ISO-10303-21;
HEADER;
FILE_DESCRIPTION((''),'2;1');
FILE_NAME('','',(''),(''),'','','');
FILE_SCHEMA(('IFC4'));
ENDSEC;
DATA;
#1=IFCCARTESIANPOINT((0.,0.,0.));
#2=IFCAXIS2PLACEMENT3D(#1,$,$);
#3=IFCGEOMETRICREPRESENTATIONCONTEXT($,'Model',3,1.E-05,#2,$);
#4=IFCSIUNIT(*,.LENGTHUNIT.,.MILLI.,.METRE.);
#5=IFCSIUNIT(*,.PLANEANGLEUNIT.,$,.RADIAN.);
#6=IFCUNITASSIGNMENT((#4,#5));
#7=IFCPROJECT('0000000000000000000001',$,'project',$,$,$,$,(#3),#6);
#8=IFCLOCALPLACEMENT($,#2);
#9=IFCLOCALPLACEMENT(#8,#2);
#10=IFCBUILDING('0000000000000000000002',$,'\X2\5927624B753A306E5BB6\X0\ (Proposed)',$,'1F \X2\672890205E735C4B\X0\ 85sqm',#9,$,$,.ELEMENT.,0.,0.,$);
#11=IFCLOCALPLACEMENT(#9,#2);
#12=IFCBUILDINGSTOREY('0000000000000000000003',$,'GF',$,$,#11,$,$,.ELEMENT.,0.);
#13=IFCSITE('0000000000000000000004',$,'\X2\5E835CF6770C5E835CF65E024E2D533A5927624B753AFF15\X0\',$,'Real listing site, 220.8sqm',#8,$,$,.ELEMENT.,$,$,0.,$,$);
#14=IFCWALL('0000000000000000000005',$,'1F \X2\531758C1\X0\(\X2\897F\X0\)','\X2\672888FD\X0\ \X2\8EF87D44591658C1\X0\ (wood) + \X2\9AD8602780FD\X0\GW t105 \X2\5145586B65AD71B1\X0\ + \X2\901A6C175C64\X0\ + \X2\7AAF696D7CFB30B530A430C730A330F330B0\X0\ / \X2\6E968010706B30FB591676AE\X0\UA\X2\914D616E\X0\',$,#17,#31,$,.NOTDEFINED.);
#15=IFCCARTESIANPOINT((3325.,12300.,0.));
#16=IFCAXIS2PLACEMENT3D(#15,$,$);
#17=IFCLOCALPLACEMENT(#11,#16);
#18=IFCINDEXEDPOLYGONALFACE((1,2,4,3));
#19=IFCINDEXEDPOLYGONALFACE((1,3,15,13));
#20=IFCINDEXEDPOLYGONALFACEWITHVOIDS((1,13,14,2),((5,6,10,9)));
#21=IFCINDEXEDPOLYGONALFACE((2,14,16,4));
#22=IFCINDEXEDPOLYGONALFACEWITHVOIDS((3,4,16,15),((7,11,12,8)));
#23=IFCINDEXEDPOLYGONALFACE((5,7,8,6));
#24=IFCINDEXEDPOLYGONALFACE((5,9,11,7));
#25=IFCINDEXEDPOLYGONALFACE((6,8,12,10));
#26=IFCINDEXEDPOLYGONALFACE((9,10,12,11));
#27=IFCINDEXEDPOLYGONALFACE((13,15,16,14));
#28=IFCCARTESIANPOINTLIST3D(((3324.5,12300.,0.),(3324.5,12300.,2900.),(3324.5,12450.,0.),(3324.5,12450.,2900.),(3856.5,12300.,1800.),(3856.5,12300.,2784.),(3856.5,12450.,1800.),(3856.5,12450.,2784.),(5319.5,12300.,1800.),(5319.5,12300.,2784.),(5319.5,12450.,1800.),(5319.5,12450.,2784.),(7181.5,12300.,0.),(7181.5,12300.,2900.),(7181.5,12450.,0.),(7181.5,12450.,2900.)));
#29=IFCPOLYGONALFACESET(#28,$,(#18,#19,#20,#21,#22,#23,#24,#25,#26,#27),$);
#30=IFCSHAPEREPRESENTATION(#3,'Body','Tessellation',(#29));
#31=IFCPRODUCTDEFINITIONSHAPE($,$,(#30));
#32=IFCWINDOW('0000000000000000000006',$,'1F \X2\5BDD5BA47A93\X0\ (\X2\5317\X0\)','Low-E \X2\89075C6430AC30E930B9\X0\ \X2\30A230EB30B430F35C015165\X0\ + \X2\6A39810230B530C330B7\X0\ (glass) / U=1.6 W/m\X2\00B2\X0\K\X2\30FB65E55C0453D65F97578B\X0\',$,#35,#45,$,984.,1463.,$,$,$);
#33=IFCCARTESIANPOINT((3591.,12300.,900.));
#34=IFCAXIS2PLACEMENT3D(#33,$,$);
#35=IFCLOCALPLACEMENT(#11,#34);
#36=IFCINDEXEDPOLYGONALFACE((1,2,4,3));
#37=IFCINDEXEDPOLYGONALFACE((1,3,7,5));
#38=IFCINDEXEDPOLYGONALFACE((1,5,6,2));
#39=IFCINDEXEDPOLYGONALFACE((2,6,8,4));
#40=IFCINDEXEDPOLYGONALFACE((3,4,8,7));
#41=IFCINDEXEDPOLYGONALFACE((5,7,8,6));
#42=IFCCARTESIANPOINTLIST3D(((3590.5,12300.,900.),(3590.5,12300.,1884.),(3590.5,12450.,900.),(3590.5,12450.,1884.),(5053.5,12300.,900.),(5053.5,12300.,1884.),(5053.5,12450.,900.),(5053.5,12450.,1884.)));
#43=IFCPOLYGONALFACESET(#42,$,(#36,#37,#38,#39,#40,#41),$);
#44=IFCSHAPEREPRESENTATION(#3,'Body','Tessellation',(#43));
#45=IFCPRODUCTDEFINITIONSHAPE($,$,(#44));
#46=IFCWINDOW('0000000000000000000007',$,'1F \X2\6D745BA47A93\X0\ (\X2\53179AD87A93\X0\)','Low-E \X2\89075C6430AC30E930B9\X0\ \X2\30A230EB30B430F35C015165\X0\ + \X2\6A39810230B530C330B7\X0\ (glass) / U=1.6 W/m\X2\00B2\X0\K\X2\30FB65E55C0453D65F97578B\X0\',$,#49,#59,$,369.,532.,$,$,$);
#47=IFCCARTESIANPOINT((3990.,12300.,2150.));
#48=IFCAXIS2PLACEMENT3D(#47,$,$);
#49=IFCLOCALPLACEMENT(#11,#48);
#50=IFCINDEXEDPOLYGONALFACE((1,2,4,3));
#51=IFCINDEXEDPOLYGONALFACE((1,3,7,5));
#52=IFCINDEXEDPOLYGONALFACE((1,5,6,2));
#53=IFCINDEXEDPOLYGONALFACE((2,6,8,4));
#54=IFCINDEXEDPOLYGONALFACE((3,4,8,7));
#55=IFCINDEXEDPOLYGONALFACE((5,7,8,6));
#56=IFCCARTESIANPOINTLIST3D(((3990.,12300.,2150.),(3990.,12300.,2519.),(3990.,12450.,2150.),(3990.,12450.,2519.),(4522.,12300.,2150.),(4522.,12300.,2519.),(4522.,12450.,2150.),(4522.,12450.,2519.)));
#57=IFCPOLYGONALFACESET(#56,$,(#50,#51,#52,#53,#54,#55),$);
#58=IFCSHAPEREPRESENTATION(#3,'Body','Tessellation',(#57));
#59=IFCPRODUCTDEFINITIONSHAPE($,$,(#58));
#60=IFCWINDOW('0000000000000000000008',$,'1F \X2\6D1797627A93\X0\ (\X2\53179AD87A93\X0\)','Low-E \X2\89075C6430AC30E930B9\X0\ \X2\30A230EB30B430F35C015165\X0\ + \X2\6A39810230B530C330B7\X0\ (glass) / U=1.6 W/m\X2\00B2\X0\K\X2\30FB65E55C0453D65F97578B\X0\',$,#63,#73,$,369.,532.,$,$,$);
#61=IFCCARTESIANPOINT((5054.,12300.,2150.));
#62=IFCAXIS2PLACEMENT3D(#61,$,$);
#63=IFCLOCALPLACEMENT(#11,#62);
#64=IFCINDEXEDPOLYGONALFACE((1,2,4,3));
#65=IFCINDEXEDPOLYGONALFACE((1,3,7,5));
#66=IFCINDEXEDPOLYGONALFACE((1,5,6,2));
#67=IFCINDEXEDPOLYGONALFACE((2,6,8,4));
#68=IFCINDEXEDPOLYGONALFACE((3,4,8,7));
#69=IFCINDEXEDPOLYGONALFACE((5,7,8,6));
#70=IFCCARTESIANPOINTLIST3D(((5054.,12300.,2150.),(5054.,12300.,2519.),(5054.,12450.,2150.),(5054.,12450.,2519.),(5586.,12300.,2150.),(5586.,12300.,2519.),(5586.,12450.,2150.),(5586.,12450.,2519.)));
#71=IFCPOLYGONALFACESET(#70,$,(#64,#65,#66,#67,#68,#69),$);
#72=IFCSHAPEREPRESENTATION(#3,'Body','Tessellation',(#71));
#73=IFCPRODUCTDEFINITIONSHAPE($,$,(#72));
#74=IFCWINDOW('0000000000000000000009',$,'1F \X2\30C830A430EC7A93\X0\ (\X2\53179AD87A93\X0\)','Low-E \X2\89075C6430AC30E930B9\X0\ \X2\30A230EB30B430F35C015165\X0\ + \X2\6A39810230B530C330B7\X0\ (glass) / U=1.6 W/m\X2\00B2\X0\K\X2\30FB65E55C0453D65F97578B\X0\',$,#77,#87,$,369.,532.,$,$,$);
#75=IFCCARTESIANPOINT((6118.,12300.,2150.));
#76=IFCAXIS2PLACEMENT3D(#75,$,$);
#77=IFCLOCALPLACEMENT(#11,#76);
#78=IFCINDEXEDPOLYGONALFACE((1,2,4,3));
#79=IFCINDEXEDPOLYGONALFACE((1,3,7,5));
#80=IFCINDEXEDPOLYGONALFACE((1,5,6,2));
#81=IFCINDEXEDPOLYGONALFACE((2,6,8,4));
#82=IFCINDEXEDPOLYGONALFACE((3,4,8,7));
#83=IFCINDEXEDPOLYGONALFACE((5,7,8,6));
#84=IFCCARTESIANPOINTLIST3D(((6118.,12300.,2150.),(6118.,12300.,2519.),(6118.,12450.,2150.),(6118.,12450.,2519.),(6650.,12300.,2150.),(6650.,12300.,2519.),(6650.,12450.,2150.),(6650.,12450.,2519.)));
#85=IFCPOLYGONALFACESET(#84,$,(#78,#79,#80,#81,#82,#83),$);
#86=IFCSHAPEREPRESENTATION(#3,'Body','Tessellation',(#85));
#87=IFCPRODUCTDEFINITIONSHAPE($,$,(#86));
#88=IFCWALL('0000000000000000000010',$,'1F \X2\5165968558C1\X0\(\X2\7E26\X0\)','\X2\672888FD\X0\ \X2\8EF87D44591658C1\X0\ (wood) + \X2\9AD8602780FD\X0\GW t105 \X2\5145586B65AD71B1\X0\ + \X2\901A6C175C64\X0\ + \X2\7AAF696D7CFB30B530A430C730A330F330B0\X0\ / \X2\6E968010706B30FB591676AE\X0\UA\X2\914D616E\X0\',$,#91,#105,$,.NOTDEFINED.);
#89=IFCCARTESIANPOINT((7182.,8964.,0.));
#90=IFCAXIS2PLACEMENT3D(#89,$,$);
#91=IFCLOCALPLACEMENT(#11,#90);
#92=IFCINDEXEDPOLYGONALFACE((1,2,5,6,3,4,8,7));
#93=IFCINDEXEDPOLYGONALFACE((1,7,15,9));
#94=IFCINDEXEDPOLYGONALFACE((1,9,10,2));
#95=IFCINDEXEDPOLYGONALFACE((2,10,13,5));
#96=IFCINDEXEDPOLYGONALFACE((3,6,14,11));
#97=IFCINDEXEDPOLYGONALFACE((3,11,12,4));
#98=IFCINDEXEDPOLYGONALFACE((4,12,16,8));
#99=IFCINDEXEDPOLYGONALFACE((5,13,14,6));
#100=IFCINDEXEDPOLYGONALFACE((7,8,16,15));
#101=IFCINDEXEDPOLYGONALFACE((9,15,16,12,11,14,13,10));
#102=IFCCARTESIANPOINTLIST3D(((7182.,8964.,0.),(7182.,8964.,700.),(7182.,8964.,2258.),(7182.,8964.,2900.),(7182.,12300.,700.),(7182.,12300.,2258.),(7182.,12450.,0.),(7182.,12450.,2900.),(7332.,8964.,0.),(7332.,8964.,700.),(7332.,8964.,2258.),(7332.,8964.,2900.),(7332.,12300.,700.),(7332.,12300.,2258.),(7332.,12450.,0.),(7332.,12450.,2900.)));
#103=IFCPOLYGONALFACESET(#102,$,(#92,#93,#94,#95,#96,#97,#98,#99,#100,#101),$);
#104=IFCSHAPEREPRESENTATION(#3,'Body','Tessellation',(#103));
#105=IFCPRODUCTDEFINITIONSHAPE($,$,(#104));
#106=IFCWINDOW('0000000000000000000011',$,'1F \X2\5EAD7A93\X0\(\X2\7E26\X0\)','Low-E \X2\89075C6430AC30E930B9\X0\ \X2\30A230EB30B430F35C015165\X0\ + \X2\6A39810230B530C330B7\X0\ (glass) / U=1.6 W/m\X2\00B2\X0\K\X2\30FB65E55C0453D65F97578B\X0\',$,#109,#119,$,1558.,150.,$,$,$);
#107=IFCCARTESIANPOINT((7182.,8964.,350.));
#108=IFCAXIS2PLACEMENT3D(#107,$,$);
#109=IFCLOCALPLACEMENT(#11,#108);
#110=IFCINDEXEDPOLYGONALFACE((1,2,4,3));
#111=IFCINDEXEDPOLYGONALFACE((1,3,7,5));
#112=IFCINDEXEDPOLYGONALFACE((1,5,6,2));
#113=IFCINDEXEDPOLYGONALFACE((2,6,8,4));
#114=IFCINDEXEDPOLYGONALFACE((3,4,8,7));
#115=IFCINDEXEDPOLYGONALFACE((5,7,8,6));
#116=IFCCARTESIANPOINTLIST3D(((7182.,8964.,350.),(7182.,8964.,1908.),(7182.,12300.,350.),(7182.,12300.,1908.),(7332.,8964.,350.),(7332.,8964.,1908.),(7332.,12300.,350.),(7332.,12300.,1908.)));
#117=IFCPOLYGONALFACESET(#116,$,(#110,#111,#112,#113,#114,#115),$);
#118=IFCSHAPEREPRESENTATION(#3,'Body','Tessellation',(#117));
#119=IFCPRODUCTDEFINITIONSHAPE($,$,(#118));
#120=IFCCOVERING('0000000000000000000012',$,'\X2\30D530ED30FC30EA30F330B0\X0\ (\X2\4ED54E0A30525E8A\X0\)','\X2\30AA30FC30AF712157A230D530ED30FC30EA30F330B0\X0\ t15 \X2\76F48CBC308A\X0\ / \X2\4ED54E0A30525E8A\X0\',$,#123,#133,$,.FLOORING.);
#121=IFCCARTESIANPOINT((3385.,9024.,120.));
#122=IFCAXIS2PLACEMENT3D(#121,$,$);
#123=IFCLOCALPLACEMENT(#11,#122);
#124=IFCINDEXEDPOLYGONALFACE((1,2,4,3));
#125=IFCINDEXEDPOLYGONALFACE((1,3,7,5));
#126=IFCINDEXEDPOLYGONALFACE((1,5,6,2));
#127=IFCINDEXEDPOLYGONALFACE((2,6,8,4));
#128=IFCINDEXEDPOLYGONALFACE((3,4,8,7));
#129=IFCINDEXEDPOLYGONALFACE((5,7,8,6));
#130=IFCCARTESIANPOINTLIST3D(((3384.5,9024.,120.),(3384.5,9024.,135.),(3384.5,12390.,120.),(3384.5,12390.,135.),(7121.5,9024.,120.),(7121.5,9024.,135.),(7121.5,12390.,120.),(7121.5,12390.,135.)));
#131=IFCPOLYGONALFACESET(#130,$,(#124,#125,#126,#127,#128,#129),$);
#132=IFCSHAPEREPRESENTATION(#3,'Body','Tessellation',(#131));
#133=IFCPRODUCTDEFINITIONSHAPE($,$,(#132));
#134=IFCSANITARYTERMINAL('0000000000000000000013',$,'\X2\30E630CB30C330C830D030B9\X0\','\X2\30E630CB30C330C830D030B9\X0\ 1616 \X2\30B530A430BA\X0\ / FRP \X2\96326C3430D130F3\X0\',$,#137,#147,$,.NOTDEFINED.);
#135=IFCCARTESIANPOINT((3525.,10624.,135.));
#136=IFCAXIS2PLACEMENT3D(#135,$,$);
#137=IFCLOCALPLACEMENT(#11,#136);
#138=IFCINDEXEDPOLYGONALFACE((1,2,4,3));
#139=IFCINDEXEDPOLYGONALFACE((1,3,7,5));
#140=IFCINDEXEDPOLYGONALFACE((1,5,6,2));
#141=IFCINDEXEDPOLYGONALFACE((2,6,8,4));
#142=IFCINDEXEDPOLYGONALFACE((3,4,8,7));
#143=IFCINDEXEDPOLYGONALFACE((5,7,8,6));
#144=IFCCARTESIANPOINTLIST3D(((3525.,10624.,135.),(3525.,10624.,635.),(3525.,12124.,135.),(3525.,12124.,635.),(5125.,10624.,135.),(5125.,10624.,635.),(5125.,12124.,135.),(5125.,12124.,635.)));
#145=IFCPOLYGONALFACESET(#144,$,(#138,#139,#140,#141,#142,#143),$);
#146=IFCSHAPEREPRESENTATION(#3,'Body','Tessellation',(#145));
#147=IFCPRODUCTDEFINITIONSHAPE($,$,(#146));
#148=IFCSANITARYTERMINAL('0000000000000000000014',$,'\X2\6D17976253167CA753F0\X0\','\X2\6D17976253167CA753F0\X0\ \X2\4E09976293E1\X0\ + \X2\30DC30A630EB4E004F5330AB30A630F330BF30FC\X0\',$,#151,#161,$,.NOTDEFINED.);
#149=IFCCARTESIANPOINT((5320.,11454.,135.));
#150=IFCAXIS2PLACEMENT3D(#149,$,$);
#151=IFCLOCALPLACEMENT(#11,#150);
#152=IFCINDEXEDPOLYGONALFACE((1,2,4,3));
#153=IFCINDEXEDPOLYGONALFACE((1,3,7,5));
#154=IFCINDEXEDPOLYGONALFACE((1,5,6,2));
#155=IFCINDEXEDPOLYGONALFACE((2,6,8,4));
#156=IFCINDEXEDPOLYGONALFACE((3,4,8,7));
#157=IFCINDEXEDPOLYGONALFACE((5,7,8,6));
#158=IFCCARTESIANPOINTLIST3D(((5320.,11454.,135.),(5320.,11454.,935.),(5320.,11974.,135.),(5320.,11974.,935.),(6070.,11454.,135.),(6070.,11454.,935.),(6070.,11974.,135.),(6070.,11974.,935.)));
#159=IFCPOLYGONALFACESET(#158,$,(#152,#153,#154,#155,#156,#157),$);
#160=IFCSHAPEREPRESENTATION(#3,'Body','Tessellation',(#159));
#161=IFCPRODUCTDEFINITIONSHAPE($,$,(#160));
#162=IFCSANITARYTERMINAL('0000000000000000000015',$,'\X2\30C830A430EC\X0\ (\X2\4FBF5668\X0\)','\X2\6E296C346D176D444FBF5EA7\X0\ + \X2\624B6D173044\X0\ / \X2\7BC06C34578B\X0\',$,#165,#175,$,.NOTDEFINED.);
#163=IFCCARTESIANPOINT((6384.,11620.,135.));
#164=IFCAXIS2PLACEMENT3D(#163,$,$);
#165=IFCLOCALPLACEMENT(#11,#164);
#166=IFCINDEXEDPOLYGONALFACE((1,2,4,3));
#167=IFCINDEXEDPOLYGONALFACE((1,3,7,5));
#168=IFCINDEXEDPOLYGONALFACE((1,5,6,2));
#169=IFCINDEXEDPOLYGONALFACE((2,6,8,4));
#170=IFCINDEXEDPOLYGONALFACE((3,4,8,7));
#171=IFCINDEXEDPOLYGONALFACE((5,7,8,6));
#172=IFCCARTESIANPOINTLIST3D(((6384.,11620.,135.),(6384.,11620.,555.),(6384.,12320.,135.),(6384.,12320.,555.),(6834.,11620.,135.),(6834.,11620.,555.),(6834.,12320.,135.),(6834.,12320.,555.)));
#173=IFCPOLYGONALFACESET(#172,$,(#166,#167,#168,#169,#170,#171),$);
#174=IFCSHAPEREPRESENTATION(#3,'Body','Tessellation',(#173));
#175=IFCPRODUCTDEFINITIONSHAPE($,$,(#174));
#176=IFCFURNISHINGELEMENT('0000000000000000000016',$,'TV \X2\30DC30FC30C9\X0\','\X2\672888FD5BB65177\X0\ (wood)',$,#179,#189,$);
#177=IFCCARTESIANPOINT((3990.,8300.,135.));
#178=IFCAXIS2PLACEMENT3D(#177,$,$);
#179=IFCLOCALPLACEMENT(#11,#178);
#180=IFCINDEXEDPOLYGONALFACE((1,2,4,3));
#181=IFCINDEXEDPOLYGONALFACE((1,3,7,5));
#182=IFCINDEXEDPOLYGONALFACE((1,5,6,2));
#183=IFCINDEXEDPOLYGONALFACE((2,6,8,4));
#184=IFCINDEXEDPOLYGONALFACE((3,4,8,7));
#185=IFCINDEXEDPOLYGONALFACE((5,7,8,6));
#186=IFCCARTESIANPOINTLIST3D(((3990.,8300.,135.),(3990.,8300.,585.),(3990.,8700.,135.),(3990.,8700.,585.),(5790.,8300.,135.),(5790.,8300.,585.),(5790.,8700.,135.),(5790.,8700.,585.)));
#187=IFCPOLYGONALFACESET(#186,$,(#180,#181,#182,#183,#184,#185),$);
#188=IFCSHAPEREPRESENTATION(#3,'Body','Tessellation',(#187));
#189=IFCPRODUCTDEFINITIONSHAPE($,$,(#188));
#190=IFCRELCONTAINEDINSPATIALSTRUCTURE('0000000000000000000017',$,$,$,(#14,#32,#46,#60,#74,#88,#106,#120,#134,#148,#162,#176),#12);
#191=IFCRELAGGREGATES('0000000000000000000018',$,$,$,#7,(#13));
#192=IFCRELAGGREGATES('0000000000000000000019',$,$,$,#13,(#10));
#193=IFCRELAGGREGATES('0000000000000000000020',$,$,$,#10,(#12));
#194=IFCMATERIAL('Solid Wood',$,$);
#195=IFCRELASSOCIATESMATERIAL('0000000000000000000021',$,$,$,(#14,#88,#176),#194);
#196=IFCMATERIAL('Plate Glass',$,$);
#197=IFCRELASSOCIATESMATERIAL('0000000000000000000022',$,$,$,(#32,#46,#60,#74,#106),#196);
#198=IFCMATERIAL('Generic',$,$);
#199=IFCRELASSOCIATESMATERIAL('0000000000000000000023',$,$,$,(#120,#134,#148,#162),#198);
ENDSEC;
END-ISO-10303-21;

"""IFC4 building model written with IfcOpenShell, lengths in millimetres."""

from ifc_helpers import new_model, si_unit, frame, frame_2d, origin, place, context, project, spatial, rectangle, extrude, material, element, fill, save


model = new_model("IFC4")

# Units and contexts
model_context = context("Model", 3, precision=1e-05, world=origin())
ifc_project = project(units=[si_unit("LENGTHUNIT", "METRE", prefix="MILLI"), si_unit("PLANEANGLEUNIT", "RADIAN")], contexts=[model_context])

# Site, building, storey
site_placement = place(None, origin())
site = spatial("IfcSite", under=ifc_project, at=site_placement, Name="広島県広島市中区大手町５", ObjectType="Real listing site, 220.8sqm", CompositionType="ELEMENT", RefElevation=0.0)
building_placement = place(site_placement, origin())
building = spatial("IfcBuilding", under=site, at=building_placement, Name="大手町の家 (Proposed)", ObjectType="1F 木造平屋 85sqm", CompositionType="ELEMENT", ElevationOfRefHeight=0.0, ElevationOfTerrain=0.0)
storey_placement = place(building_placement, origin())
storey = spatial("IfcBuildingStorey", under=building, at=storey_placement, Name="GF", CompositionType="ELEMENT", Elevation=0.0)

# Shared definitions
ifc_material_1 = material(Name="Solid Wood")

# Wall, openings, windows
wall_1_placement = place(storey_placement, frame((3325.0, 12300.0, 0.0)))
wall_1 = element("IfcWall", 1, at=wall_1_placement, inside=storey, material=ifc_material_1, Name="1F 北壁(西)", Description="木製 軸組外壁 (wood) + 高性能GW t105 充填断熱 + 通気層 + 窯業系サイディング / 準耐火・外皮UA配慮", PredefinedType="NOTDEFINED", context=model_context, shape_type="SweptSolid", body=[
    extrude(rectangle(XDim=3857.0, YDim=150.0, at=frame_2d((1928.0, 75.0))), frame((3325.0, 12300.0, 0.0)), (0.0, 0.0, 1.0), 2900.0),
])
opening_1_placement = place(storey_placement, frame((3591.0, 12300.0, 900.0)))
opening_1 = element("IfcOpeningElement", 2, at=opening_1_placement, cuts=wall_1, PredefinedType="NOTDEFINED", context=model_context, shape_type="SweptSolid", body=[
    extrude(rectangle(XDim=1463.0, YDim=150.0, at=frame_2d((731.0, 75.0))), frame((3591.0, 12300.0, 900.0)), (0.0, 0.0, 1.0), 984.0),
])
opening_2_placement = place(storey_placement, frame((3990.0, 12300.0, 2150.0)))
opening_2 = element("IfcOpeningElement", 3, at=opening_2_placement, cuts=wall_1, PredefinedType="NOTDEFINED", context=model_context, shape_type="SweptSolid", body=[
    extrude(rectangle(XDim=532.0, YDim=150.0, at=frame_2d((266.0, 75.0))), frame((3990.0, 12300.0, 2150.0)), (0.0, 0.0, 1.0), 369.0),
])
opening_3_placement = place(storey_placement, frame((5054.0, 12300.0, 2150.0)))
opening_3 = element("IfcOpeningElement", 4, at=opening_3_placement, cuts=wall_1, PredefinedType="NOTDEFINED", context=model_context, shape_type="SweptSolid", body=[
    extrude(rectangle(XDim=532.0, YDim=150.0, at=frame_2d((266.0, 75.0))), frame((5054.0, 12300.0, 2150.0)), (0.0, 0.0, 1.0), 369.0),
])
opening_4_placement = place(storey_placement, frame((6118.0, 12300.0, 2150.0)))
opening_4 = element("IfcOpeningElement", 5, at=opening_4_placement, cuts=wall_1, PredefinedType="NOTDEFINED", context=model_context, shape_type="SweptSolid", body=[
    extrude(rectangle(XDim=532.0, YDim=150.0, at=frame_2d((266.0, 75.0))), frame((6118.0, 12300.0, 2150.0)), (0.0, 0.0, 1.0), 369.0),
])
ifc_material_2 = material(Name="Plate Glass")
window_1_placement = place(storey_placement, frame((3591.0, 12300.0, 900.0)))
window_1 = element("IfcWindow", 6, at=window_1_placement, inside=storey, material=ifc_material_2, Name="1F 寝室窓 (北)", Description="Low-E 複層ガラス アルゴン封入 + 樹脂サッシ (glass) / U=1.6 W/m²K・日射取得型", OverallHeight=984.0, OverallWidth=1463.0, context=model_context, shape_type="SweptSolid", body=[
    extrude(rectangle(XDim=1463.0, YDim=150.0, at=frame_2d((731.0, 75.0))), frame((3591.0, 12300.0, 900.0)), (0.0, 0.0, 1.0), 984.0),
])
fill(opening_1, window_1)
window_2_placement = place(storey_placement, frame((3990.0, 12300.0, 2150.0)))
window_2 = element("IfcWindow", 7, at=window_2_placement, inside=storey, material=ifc_material_2, Name="1F 浴室窓 (北高窓)", Description="Low-E 複層ガラス アルゴン封入 + 樹脂サッシ (glass) / U=1.6 W/m²K・日射取得型", OverallHeight=369.0, OverallWidth=532.0, context=model_context, shape_type="SweptSolid", body=[
    extrude(rectangle(XDim=532.0, YDim=150.0, at=frame_2d((266.0, 75.0))), frame((3990.0, 12300.0, 2150.0)), (0.0, 0.0, 1.0), 369.0),
])
fill(opening_2, window_2)
window_3_placement = place(storey_placement, frame((5054.0, 12300.0, 2150.0)))
window_3 = element("IfcWindow", 8, at=window_3_placement, inside=storey, material=ifc_material_2, Name="1F 洗面窓 (北高窓)", Description="Low-E 複層ガラス アルゴン封入 + 樹脂サッシ (glass) / U=1.6 W/m²K・日射取得型", OverallHeight=369.0, OverallWidth=532.0, context=model_context, shape_type="SweptSolid", body=[
    extrude(rectangle(XDim=532.0, YDim=150.0, at=frame_2d((266.0, 75.0))), frame((5054.0, 12300.0, 2150.0)), (0.0, 0.0, 1.0), 369.0),
])
fill(opening_3, window_3)
window_4_placement = place(storey_placement, frame((6118.0, 12300.0, 2150.0)))
window_4 = element("IfcWindow", 9, at=window_4_placement, inside=storey, material=ifc_material_2, Name="1F トイレ窓 (北高窓)", Description="Low-E 複層ガラス アルゴン封入 + 樹脂サッシ (glass) / U=1.6 W/m²K・日射取得型", OverallHeight=369.0, OverallWidth=532.0, context=model_context, shape_type="SweptSolid", body=[
    extrude(rectangle(XDim=532.0, YDim=150.0, at=frame_2d((266.0, 75.0))), frame((6118.0, 12300.0, 2150.0)), (0.0, 0.0, 1.0), 369.0),
])
fill(opening_4, window_4)

# Wall, opening, window
wall_2_placement = place(storey_placement, frame((7182.0, 8964.0, 0.0)))
wall_2 = element("IfcWall", 10, at=wall_2_placement, inside=storey, material=ifc_material_1, Name="1F 入隅壁(縦)", Description="木製 軸組外壁 (wood) + 高性能GW t105 充填断熱 + 通気層 + 窯業系サイディング / 準耐火・外皮UA配慮", PredefinedType="NOTDEFINED", context=model_context, shape_type="SweptSolid", body=[
    extrude(rectangle(XDim=150.0, YDim=3486.0, at=frame_2d((75.0, 1743.0))), frame((7182.0, 8964.0, 0.0)), (0.0, 0.0, 1.0), 2900.0),
])
opening_5_placement = place(storey_placement, frame((7182.0, 8964.0, 350.0)))
opening_5 = element("IfcOpeningElement", 11, at=opening_5_placement, cuts=wall_2, PredefinedType="NOTDEFINED", context=model_context, shape_type="SweptSolid", body=[
    extrude(rectangle(XDim=150.0, YDim=3336.0, at=frame_2d((75.0, 1668.0))), frame((7182.0, 8964.0, 350.0)), (0.0, 0.0, 1.0), 1558.0),
])
window_5_placement = place(storey_placement, frame((7182.0, 8964.0, 350.0)))
window_5 = element("IfcWindow", 12, at=window_5_placement, inside=storey, material=ifc_material_2, Name="1F 庭窓(縦)", Description="Low-E 複層ガラス アルゴン封入 + 樹脂サッシ (glass) / U=1.6 W/m²K・日射取得型", OverallHeight=1558.0, OverallWidth=150.0, context=model_context, shape_type="SweptSolid", body=[
    extrude(rectangle(XDim=150.0, YDim=3336.0, at=frame_2d((75.0, 1668.0))), frame((7182.0, 8964.0, 350.0)), (0.0, 0.0, 1.0), 1558.0),
])
fill(opening_5, window_5)

# Covering
ifc_material_3 = material(Name="Generic")
covering_placement = place(storey_placement, frame((3385.0, 9024.0, 120.0)))
element("IfcCovering", 13, at=covering_placement, inside=storey, material=ifc_material_3, Name="フローリング (仕上げ床)", Description="オーク無垢フローリング t15 直貼り / 仕上げ床", PredefinedType="FLOORING", context=model_context, shape_type="SweptSolid", body=[
    extrude(rectangle(XDim=3737.0, YDim=3366.0, at=frame_2d((1868.0, 1683.0))), frame((3385.0, 9024.0, 120.0)), (0.0, 0.0, 1.0), 15.0),
])

# Sanitary terminals
sanitary_terminal_1_placement = place(storey_placement, frame((3525.0, 10624.0, 135.0)))
element("IfcSanitaryTerminal", 14, at=sanitary_terminal_1_placement, inside=storey, material=ifc_material_3, Name="ユニットバス", Description="ユニットバス 1616 サイズ / FRP 防水パン", PredefinedType="NOTDEFINED", context=model_context, shape_type="SweptSolid", body=[
    extrude(rectangle(XDim=1600.0, YDim=1500.0, at=frame_2d((800.0, 750.0))), frame((3525.0, 10624.0, 135.0)), (0.0, 0.0, 1.0), 500.0),
])
sanitary_terminal_2_placement = place(storey_placement, frame((5320.0, 11454.0, 135.0)))
element("IfcSanitaryTerminal", 15, at=sanitary_terminal_2_placement, inside=storey, material=ifc_material_3, Name="洗面化粧台", Description="洗面化粧台 三面鏡 + ボウル一体カウンター", PredefinedType="NOTDEFINED", context=model_context, shape_type="SweptSolid", body=[
    extrude(rectangle(XDim=750.0, YDim=520.0, at=frame_2d((375.0, 260.0))), frame((5320.0, 11454.0, 135.0)), (0.0, 0.0, 1.0), 800.0),
])
sanitary_terminal_3_placement = place(storey_placement, frame((6384.0, 11620.0, 135.0)))
element("IfcSanitaryTerminal", 16, at=sanitary_terminal_3_placement, inside=storey, material=ifc_material_3, Name="トイレ (便器)", Description="温水洗浄便座 + 手洗い / 節水型", PredefinedType="NOTDEFINED", context=model_context, shape_type="SweptSolid", body=[
    extrude(rectangle(XDim=450.0, YDim=700.0, at=frame_2d((225.0, 350.0))), frame((6384.0, 11620.0, 135.0)), (0.0, 0.0, 1.0), 420.0),
])

# Furnishing element
furnishing_placement = place(storey_placement, frame((3990.0, 8300.0, 135.0)))
element("IfcFurnishingElement", 17, at=furnishing_placement, inside=storey, material=ifc_material_1, Name="TV ボード", Description="木製家具 (wood)", context=model_context, shape_type="SweptSolid", body=[
    extrude(rectangle(XDim=1800.0, YDim=400.0, at=frame_2d((900.0, 200.0))), frame((3990.0, 8300.0, 135.0)), (0.0, 0.0, 1.0), 450.0),
])

save(model, "model.ifc")
